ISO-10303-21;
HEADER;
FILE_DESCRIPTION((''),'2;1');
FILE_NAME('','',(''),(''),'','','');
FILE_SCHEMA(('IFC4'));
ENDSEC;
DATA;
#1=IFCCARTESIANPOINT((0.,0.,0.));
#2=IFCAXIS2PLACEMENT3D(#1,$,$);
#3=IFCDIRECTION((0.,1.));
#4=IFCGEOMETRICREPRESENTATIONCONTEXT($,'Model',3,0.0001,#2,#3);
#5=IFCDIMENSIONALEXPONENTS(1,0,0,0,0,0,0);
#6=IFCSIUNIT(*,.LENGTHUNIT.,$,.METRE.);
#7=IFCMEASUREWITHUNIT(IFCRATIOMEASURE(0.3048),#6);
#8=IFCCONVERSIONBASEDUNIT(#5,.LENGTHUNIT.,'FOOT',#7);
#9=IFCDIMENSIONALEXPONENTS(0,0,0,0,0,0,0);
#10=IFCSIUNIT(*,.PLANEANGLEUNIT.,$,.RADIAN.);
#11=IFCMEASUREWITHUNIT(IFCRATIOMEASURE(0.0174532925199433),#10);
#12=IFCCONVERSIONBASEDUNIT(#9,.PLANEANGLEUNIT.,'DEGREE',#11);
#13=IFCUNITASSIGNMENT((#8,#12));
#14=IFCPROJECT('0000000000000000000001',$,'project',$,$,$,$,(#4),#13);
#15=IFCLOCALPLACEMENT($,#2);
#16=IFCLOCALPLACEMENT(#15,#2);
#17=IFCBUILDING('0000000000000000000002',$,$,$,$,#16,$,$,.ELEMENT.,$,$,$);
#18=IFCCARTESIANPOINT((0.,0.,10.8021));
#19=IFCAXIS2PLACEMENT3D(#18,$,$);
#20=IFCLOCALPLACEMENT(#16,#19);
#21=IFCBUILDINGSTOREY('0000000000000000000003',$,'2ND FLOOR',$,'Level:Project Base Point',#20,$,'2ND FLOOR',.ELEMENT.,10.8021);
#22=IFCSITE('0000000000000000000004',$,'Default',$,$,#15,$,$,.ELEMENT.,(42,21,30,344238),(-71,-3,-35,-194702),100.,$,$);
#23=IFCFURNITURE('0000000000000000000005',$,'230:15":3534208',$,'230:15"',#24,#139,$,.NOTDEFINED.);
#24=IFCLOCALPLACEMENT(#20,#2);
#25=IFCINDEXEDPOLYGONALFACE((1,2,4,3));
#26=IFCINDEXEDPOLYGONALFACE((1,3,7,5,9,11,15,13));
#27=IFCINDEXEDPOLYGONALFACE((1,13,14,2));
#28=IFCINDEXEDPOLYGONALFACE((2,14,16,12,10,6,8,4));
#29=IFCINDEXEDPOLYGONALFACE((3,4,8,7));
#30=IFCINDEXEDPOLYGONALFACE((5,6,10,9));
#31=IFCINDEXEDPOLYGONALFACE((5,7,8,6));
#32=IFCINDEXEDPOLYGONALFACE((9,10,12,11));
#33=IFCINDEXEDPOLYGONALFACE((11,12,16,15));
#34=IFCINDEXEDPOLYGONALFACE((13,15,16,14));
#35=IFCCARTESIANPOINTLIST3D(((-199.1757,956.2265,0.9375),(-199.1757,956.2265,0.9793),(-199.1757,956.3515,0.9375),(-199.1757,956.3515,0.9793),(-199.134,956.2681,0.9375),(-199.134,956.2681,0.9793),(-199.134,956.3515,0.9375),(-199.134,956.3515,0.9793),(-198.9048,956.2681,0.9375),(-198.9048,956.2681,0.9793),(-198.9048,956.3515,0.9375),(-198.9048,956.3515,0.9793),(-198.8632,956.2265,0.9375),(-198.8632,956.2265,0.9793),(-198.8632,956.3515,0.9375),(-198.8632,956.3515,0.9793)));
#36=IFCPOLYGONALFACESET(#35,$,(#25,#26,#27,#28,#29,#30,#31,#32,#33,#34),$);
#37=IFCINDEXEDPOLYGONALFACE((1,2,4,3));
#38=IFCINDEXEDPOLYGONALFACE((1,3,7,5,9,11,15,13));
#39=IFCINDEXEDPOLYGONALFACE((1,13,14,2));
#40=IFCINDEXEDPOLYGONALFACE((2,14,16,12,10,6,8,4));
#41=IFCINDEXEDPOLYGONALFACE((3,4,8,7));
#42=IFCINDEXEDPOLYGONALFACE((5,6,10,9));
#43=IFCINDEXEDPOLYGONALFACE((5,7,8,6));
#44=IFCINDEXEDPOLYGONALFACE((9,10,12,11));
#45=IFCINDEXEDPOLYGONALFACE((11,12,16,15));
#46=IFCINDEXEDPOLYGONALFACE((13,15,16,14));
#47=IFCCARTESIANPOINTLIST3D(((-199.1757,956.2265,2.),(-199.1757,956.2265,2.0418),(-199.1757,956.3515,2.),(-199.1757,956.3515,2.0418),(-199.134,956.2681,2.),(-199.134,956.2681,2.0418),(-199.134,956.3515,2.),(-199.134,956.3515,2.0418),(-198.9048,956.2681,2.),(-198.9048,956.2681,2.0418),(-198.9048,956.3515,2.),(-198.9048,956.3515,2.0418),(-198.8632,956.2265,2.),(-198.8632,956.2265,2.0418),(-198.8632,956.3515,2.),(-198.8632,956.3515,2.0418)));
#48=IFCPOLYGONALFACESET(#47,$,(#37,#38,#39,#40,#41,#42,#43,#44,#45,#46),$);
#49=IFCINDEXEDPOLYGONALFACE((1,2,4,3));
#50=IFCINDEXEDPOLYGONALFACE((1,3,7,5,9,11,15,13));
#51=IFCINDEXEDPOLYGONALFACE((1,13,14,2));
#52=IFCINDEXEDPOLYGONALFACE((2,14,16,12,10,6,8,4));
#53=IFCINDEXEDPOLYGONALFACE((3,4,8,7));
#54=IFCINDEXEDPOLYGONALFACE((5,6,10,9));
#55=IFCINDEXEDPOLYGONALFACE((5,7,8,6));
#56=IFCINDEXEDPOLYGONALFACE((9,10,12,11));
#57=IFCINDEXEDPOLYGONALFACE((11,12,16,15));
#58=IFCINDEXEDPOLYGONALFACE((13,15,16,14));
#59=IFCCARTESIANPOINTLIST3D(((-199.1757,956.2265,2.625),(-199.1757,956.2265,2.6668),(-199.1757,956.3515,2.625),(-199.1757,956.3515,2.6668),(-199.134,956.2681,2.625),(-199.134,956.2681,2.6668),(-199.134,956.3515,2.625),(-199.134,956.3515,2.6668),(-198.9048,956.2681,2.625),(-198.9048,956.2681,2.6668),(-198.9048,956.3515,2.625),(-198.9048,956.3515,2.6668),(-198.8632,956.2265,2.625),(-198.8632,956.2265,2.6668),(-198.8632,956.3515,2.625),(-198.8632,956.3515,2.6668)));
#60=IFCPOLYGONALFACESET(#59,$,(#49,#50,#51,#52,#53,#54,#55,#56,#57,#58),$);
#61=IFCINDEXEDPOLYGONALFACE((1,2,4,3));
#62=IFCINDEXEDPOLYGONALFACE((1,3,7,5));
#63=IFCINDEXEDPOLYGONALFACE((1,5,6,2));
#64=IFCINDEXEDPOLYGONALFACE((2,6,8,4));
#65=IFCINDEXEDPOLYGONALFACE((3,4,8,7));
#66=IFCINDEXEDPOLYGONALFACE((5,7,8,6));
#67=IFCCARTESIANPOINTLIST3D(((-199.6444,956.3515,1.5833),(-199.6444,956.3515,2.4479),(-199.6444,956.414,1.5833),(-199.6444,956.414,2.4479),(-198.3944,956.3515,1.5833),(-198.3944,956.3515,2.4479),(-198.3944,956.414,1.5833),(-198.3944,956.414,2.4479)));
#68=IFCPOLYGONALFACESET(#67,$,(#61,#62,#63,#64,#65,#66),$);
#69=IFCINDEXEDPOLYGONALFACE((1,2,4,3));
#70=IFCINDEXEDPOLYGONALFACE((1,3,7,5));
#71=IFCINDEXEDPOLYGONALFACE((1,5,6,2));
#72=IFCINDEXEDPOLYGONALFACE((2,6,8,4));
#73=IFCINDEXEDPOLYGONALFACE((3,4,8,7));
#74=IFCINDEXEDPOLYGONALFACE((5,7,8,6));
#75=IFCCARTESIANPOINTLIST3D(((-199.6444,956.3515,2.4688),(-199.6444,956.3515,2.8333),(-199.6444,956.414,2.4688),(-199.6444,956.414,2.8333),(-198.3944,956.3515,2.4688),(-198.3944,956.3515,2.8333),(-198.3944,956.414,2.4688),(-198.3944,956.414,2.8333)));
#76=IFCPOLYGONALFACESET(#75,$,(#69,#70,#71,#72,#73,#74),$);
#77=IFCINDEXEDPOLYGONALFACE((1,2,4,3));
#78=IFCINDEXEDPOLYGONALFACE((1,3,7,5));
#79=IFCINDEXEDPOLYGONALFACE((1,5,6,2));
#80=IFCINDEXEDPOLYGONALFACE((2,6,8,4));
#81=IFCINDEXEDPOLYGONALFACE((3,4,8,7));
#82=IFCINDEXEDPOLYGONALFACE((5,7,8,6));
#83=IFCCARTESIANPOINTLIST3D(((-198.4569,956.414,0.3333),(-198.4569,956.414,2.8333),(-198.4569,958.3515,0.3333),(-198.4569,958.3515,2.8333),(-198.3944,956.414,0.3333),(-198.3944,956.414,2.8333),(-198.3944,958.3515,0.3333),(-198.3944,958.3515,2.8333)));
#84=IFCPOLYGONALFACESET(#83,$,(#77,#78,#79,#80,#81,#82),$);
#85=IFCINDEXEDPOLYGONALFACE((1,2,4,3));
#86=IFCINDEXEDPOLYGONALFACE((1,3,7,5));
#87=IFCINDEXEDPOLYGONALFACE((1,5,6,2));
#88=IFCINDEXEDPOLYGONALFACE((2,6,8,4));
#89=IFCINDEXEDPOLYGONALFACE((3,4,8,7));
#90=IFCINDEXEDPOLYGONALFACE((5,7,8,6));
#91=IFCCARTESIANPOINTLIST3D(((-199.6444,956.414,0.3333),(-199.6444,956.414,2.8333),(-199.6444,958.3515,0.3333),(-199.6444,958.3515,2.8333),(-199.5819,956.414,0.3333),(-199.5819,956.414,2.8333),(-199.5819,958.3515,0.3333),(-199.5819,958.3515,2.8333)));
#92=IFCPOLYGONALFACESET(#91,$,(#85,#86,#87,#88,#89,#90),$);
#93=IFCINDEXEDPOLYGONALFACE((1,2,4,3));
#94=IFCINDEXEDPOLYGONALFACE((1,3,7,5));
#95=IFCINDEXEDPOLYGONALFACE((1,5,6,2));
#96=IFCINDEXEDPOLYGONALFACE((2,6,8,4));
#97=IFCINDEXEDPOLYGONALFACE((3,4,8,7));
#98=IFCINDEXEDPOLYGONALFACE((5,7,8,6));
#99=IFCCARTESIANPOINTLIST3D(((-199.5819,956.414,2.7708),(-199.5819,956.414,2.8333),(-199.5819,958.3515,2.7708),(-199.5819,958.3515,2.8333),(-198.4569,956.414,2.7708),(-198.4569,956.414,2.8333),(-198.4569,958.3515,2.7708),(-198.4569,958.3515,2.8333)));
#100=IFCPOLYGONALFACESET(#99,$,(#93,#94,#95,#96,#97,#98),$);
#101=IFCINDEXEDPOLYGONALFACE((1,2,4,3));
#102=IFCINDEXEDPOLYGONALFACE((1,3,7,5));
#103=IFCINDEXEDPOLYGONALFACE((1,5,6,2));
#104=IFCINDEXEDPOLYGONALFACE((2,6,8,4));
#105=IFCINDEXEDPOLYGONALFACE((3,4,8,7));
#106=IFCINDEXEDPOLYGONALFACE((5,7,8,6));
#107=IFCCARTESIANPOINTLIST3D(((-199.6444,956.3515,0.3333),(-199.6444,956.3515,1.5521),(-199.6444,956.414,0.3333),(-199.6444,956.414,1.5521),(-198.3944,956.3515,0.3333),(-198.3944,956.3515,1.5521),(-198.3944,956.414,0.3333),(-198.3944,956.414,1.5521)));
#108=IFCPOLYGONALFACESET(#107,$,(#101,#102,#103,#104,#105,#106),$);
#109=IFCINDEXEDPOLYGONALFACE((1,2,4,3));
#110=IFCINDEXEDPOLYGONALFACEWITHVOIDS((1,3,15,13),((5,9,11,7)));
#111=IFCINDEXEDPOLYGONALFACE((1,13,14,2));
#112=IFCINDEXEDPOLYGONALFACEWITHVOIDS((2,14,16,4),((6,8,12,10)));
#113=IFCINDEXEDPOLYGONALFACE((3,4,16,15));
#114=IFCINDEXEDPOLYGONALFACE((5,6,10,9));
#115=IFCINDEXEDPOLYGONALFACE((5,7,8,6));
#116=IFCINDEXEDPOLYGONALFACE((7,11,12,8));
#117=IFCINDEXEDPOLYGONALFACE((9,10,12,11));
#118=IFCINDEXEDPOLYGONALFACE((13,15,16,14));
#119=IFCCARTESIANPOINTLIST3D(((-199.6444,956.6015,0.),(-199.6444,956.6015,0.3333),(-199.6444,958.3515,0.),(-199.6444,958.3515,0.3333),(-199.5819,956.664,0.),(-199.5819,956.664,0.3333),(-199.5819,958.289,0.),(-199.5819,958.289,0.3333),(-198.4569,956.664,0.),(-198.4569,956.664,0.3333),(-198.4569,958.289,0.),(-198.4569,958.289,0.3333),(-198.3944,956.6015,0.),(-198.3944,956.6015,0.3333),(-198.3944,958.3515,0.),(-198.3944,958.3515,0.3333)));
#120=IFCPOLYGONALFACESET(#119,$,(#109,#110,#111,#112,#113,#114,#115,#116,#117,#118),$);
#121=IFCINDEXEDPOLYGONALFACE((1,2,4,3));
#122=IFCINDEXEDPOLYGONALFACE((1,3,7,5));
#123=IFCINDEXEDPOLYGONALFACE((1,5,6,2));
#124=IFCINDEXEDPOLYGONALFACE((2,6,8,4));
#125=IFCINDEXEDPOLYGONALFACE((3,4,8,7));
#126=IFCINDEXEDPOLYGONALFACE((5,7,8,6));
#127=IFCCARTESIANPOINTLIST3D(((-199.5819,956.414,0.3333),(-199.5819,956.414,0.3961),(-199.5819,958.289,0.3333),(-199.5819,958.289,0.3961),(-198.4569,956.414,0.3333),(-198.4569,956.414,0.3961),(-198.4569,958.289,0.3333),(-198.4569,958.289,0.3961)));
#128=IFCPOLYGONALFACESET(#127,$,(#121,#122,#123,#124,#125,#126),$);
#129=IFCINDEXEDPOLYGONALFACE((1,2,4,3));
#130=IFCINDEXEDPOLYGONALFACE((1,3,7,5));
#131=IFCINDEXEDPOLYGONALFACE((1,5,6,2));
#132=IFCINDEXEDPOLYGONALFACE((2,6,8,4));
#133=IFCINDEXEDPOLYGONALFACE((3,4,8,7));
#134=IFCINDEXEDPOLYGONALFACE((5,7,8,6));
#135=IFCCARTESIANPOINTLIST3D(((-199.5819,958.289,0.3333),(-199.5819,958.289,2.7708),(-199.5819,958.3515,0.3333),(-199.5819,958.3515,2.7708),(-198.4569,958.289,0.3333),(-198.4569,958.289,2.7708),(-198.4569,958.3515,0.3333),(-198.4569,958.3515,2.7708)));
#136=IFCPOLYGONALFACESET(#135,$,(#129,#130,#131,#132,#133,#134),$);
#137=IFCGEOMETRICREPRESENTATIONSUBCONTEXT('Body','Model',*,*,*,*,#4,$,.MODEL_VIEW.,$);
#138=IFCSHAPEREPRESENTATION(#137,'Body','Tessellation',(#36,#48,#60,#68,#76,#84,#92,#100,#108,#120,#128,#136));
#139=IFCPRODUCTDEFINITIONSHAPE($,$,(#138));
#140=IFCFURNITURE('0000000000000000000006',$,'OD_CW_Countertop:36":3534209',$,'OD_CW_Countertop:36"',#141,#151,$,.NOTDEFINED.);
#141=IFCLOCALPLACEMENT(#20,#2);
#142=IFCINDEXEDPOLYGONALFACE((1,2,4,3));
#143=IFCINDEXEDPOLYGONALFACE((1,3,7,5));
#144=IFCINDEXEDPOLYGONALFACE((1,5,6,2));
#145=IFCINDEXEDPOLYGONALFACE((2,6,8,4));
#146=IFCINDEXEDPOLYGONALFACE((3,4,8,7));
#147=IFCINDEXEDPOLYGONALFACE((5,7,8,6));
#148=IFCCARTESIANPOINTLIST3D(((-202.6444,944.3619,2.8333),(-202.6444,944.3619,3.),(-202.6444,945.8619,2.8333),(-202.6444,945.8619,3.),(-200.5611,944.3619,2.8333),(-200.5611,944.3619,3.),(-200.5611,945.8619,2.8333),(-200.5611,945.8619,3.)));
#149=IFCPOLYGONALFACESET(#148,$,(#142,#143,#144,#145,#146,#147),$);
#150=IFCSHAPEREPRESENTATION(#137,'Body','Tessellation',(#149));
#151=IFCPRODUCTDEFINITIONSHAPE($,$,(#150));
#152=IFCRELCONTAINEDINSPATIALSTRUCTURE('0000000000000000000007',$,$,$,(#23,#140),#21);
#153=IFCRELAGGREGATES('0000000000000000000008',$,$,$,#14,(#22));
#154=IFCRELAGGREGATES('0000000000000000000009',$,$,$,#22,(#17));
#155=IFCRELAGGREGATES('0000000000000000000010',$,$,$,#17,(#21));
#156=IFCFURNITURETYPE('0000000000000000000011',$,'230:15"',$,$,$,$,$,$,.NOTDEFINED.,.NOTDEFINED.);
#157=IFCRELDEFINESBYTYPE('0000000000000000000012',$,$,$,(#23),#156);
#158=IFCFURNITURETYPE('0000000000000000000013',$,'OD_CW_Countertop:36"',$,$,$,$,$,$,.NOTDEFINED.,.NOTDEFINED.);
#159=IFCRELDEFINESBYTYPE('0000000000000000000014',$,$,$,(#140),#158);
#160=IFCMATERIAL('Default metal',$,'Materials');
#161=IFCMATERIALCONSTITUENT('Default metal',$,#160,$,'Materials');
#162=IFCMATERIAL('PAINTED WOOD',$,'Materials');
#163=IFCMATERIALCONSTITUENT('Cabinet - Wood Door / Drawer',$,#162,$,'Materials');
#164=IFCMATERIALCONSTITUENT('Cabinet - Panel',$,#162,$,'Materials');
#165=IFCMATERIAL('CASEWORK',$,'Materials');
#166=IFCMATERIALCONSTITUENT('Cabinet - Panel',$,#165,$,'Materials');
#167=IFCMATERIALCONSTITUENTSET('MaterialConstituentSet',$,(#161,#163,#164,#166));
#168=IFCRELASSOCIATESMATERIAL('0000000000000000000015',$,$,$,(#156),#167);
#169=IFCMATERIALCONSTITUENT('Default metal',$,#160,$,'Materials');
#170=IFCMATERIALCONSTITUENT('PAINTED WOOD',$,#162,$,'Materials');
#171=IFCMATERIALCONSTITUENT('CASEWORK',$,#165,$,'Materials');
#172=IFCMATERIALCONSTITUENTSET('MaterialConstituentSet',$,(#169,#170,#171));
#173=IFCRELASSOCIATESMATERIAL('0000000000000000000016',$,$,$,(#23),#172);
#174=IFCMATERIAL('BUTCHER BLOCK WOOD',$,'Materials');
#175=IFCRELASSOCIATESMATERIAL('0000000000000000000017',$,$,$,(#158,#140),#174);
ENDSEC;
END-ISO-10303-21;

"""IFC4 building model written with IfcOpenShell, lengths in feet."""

from ifc_helpers import new_model, entity, si_unit, converted_unit, direction, frame, frame_2d, origin, origin_2d_with_axis, place, context, subcontext, project, spatial, polyline, rectangle, outline, extrude, source, transform, mapped, material, constituent, constituent_set, type_object, type_shapes, element, save


model = new_model("IFC4")

# Units and contexts
model_context = context("Model", 3, precision=0.0001, world=origin(), true_north=direction((0.0, 1.0)))
body_context = subcontext(model_context, "Body", "Model", "MODEL_VIEW")
ifc_project = project(units=[converted_unit("LENGTHUNIT", "FOOT", entity("IfcRatioMeasure", 0.3048), si_unit("LENGTHUNIT", "METRE"), dimensions=[1, 0, 0, 0, 0, 0, 0]), converted_unit("PLANEANGLEUNIT", "DEGREE", entity("IfcRatioMeasure", 0.0174532925199433), si_unit("PLANEANGLEUNIT", "RADIAN"), dimensions=[0, 0, 0, 0, 0, 0, 0])], contexts=[model_context])

# Site, building, storey
site_placement = place(None, origin())
site = spatial("IfcSite", under=ifc_project, at=site_placement, Name="Default", CompositionType="ELEMENT", RefLatitude=(42, 21, 30, 344238), RefLongitude=(-71, -3, -35, -194702), RefElevation=100.0)
building_placement = place(site_placement, origin())
building = spatial("IfcBuilding", under=site, at=building_placement, CompositionType="ELEMENT")
storey_placement = place(building_placement, frame((0.0, 0.0, 10.8021)))
storey = spatial("IfcBuildingStorey", under=building, at=storey_placement, Name="2ND FLOOR", ObjectType="Level:Project Base Point", LongName="2ND FLOOR", CompositionType="ELEMENT", Elevation=10.8021)

# Furniture
ifc_material_1 = material(Name="CASEWORK", Category="Materials")
ifc_material_2 = material(Name="Default metal", Category="Materials")
ifc_material_3 = material(Name="PAINTED WOOD", Category="Materials")
ifc_material_4 = material(Name="BUTCHER BLOCK WOOD", Category="Materials")
ifc_constituent_1 = constituent(ifc_material_2, Name="Default metal", Category="Materials")
ifc_constituent_2 = constituent(ifc_material_3, Name="PAINTED WOOD", Category="Materials")
ifc_constituent_3 = constituent(ifc_material_1, Name="CASEWORK", Category="Materials")
ifc_constituent_set_1 = constituent_set(constituents=[ifc_constituent_1, ifc_constituent_2, ifc_constituent_3], Name="MaterialConstituentSet")
ifc_constituent_4 = constituent(ifc_material_2, Name="Default metal", Category="Materials")
ifc_constituent_5 = constituent(ifc_material_3, Name="Cabinet - Wood Door / Drawer", Category="Materials")
ifc_constituent_6 = constituent(ifc_material_3, Name="Cabinet - Panel", Category="Materials")
ifc_constituent_7 = constituent(ifc_material_1, Name="Cabinet - Panel", Category="Materials")
ifc_constituent_set_2 = constituent_set(constituents=[ifc_constituent_4, ifc_constituent_5, ifc_constituent_6, ifc_constituent_7], Name="MaterialConstituentSet")
furniture_type_1 = type_object("IfcFurnitureType", Name="230:15\"", AssemblyPlace="NOTDEFINED", PredefinedType="NOTDEFINED", material=ifc_constituent_set_2)
shared_shape_1 = source(origin(), body_context, "Body", "SweptSolid", [
    extrude(outline(polyline([(-0.1562, -0.0521), (-0.1146, -0.0521), (-0.1146, 0.0313), (0.1146, 0.0313), (0.1146, -0.0521), (0.1562, -0.0521), (0.1562, 0.0729), (-0.1562, 0.0729), (-0.1562, -0.0521)])), frame((0.0615, 2.0521, 0.9375)), (0.0, 0.0, 1.0), 0.0418),
    extrude(outline(polyline([(-0.1562, -0.0521), (-0.1146, -0.0521), (-0.1146, 0.0313), (0.1146, 0.0313), (0.1146, -0.0521), (0.1562, -0.0521), (0.1562, 0.0729), (-0.1562, 0.0729), (-0.1562, -0.0521)])), frame((0.0615, 2.0521, 2.0)), (0.0, 0.0, 1.0), 0.0418),
    extrude(outline(polyline([(-0.1562, -0.0521), (-0.1146, -0.0521), (-0.1146, 0.0313), (0.1146, 0.0313), (0.1146, -0.0521), (0.1562, -0.0521), (0.1562, 0.0729), (-0.1562, 0.0729), (-0.1562, -0.0521)])), frame((0.0615, 2.0521, 2.625)), (0.0, 0.0, 1.0), 0.0418),
    extrude(rectangle(XDim=1.25, YDim=0.0625, at=frame_2d((0.0, 0.0), x_axis=(1.0, 0.0))), frame((0.0615, 1.9688, 1.5833), z_axis=(0.0, 0.0, 1.0), x_axis=(-1.0, 0.0, 0.0)), (0.0, 0.0, 1.0), 0.8646),
    extrude(rectangle(XDim=1.25, YDim=0.0625, at=frame_2d((0.0, 0.0), x_axis=(1.0, 0.0))), frame((0.0615, 1.9688, 2.4688), z_axis=(0.0, 0.0, 1.0), x_axis=(-1.0, 0.0, 0.0)), (0.0, 0.0, 1.0), 0.3646),
    extrude(rectangle(XDim=1.9375, YDim=0.0625, at=frame_2d((0.0, 0.0), x_axis=(1.0, 0.0))), frame((-0.5323, 0.9687, 0.3333), z_axis=(0.0, 0.0, 1.0), x_axis=(0.0, -1.0, 0.0)), (0.0, 0.0, 1.0), 2.5),
    extrude(rectangle(XDim=1.9375, YDim=0.0625, at=frame_2d((0.0, 0.0), x_axis=(1.0, 0.0))), frame((0.6552, 0.9687, 0.3333), z_axis=(0.0, 0.0, 1.0), x_axis=(0.0, -1.0, 0.0)), (0.0, 0.0, 1.0), 2.5),
    extrude(rectangle(XDim=1.9375, YDim=1.125, at=origin_2d_with_axis()), frame((0.0615, 0.9687, 2.7708), z_axis=(0.0, 0.0, 1.0), x_axis=(0.0, 1.0, 0.0)), (0.0, 0.0, 1.0), 0.0625),
    extrude(rectangle(XDim=1.25, YDim=0.0625, at=frame_2d((0.0, 0.0), x_axis=(1.0, 0.0))), frame((0.0615, 1.9688, 0.3333), z_axis=(0.0, 0.0, 1.0), x_axis=(-1.0, 0.0, 0.0)), (0.0, 0.0, 1.0), 1.2187),
    extrude(outline(polyline([(-0.875, -0.625), (0.875, -0.625), (0.875, 0.625), (-0.875, 0.625), (-0.875, -0.625)]), holes=[polyline([(-0.8125, -0.5625), (-0.8125, 0.5625), (0.8125, 0.5625), (0.8125, -0.5625), (-0.8125, -0.5625)])]), frame((0.0615, 0.875, 0.0), z_axis=(0.0, 0.0, 1.0), x_axis=(0.0, -1.0, 0.0)), (0.0, 0.0, 1.0), 0.3333),
    extrude(rectangle(XDim=1.875, YDim=1.125, at=origin_2d_with_axis()), frame((0.0615, 1.0, 0.3333), z_axis=(0.0, 0.0, 1.0), x_axis=(0.0, 1.0, 0.0)), (0.0, 0.0, 1.0), 0.0627),
    extrude(rectangle(XDim=1.125, YDim=0.0625, at=origin_2d_with_axis()), frame((0.0615, 0.0312, 0.3333), z_axis=(0.0, 0.0, 1.0), x_axis=(-1.0, 0.0, 0.0)), (0.0, 0.0, 1.0), 2.4375),
])
type_shapes(furniture_type_1, [shared_shape_1])
furniture_1_placement = place(storey_placement, frame((-198.9579, 958.3515, 0.0), z_axis=(0.0, 0.0, 1.0), x_axis=(-1.0, 0.0, 0.0)))
element("IfcFurniture", 1, at=furniture_1_placement, inside=storey, type_object=furniture_type_1, material=ifc_constituent_set_1, Name="230:15\":3534208", ObjectType="230:15\"", PredefinedType="NOTDEFINED", context=body_context, shape_type="MappedRepresentation", body=[
    mapped(shared_shape_1, transform((0.0, 0.0, 0.0), scale=1.0)),
])
furniture_type_2 = type_object("IfcFurnitureType", Name="OD_CW_Countertop:36\"", AssemblyPlace="NOTDEFINED", PredefinedType="NOTDEFINED", material=ifc_material_4)
shared_shape_2 = source(origin(), body_context, "Body", "SweptSolid", [
    extrude(rectangle(XDim=2.0833, YDim=1.5, at=origin_2d_with_axis()), frame((0.75, 1.0417, 0.0), z_axis=(0.0, 0.0, 1.0), x_axis=(0.0, -1.0, 0.0)), (0.0, 0.0, 1.0), 0.1667),
])
type_shapes(furniture_type_2, [shared_shape_2])
furniture_2_placement = place(storey_placement, frame((-200.5611, 944.3619, 2.8333), z_axis=(0.0, 0.0, 1.0), x_axis=(0.0, 1.0, 0.0)))
element("IfcFurniture", 2, at=furniture_2_placement, inside=storey, type_object=furniture_type_2, material=ifc_material_4, Name="OD_CW_Countertop:36\":3534209", ObjectType="OD_CW_Countertop:36\"", PredefinedType="NOTDEFINED", context=body_context, shape_type="MappedRepresentation", body=[
    mapped(shared_shape_2, transform((0.0, 0.0, 0.0), scale=1.0)),
])

save(model, "model.ifc")
